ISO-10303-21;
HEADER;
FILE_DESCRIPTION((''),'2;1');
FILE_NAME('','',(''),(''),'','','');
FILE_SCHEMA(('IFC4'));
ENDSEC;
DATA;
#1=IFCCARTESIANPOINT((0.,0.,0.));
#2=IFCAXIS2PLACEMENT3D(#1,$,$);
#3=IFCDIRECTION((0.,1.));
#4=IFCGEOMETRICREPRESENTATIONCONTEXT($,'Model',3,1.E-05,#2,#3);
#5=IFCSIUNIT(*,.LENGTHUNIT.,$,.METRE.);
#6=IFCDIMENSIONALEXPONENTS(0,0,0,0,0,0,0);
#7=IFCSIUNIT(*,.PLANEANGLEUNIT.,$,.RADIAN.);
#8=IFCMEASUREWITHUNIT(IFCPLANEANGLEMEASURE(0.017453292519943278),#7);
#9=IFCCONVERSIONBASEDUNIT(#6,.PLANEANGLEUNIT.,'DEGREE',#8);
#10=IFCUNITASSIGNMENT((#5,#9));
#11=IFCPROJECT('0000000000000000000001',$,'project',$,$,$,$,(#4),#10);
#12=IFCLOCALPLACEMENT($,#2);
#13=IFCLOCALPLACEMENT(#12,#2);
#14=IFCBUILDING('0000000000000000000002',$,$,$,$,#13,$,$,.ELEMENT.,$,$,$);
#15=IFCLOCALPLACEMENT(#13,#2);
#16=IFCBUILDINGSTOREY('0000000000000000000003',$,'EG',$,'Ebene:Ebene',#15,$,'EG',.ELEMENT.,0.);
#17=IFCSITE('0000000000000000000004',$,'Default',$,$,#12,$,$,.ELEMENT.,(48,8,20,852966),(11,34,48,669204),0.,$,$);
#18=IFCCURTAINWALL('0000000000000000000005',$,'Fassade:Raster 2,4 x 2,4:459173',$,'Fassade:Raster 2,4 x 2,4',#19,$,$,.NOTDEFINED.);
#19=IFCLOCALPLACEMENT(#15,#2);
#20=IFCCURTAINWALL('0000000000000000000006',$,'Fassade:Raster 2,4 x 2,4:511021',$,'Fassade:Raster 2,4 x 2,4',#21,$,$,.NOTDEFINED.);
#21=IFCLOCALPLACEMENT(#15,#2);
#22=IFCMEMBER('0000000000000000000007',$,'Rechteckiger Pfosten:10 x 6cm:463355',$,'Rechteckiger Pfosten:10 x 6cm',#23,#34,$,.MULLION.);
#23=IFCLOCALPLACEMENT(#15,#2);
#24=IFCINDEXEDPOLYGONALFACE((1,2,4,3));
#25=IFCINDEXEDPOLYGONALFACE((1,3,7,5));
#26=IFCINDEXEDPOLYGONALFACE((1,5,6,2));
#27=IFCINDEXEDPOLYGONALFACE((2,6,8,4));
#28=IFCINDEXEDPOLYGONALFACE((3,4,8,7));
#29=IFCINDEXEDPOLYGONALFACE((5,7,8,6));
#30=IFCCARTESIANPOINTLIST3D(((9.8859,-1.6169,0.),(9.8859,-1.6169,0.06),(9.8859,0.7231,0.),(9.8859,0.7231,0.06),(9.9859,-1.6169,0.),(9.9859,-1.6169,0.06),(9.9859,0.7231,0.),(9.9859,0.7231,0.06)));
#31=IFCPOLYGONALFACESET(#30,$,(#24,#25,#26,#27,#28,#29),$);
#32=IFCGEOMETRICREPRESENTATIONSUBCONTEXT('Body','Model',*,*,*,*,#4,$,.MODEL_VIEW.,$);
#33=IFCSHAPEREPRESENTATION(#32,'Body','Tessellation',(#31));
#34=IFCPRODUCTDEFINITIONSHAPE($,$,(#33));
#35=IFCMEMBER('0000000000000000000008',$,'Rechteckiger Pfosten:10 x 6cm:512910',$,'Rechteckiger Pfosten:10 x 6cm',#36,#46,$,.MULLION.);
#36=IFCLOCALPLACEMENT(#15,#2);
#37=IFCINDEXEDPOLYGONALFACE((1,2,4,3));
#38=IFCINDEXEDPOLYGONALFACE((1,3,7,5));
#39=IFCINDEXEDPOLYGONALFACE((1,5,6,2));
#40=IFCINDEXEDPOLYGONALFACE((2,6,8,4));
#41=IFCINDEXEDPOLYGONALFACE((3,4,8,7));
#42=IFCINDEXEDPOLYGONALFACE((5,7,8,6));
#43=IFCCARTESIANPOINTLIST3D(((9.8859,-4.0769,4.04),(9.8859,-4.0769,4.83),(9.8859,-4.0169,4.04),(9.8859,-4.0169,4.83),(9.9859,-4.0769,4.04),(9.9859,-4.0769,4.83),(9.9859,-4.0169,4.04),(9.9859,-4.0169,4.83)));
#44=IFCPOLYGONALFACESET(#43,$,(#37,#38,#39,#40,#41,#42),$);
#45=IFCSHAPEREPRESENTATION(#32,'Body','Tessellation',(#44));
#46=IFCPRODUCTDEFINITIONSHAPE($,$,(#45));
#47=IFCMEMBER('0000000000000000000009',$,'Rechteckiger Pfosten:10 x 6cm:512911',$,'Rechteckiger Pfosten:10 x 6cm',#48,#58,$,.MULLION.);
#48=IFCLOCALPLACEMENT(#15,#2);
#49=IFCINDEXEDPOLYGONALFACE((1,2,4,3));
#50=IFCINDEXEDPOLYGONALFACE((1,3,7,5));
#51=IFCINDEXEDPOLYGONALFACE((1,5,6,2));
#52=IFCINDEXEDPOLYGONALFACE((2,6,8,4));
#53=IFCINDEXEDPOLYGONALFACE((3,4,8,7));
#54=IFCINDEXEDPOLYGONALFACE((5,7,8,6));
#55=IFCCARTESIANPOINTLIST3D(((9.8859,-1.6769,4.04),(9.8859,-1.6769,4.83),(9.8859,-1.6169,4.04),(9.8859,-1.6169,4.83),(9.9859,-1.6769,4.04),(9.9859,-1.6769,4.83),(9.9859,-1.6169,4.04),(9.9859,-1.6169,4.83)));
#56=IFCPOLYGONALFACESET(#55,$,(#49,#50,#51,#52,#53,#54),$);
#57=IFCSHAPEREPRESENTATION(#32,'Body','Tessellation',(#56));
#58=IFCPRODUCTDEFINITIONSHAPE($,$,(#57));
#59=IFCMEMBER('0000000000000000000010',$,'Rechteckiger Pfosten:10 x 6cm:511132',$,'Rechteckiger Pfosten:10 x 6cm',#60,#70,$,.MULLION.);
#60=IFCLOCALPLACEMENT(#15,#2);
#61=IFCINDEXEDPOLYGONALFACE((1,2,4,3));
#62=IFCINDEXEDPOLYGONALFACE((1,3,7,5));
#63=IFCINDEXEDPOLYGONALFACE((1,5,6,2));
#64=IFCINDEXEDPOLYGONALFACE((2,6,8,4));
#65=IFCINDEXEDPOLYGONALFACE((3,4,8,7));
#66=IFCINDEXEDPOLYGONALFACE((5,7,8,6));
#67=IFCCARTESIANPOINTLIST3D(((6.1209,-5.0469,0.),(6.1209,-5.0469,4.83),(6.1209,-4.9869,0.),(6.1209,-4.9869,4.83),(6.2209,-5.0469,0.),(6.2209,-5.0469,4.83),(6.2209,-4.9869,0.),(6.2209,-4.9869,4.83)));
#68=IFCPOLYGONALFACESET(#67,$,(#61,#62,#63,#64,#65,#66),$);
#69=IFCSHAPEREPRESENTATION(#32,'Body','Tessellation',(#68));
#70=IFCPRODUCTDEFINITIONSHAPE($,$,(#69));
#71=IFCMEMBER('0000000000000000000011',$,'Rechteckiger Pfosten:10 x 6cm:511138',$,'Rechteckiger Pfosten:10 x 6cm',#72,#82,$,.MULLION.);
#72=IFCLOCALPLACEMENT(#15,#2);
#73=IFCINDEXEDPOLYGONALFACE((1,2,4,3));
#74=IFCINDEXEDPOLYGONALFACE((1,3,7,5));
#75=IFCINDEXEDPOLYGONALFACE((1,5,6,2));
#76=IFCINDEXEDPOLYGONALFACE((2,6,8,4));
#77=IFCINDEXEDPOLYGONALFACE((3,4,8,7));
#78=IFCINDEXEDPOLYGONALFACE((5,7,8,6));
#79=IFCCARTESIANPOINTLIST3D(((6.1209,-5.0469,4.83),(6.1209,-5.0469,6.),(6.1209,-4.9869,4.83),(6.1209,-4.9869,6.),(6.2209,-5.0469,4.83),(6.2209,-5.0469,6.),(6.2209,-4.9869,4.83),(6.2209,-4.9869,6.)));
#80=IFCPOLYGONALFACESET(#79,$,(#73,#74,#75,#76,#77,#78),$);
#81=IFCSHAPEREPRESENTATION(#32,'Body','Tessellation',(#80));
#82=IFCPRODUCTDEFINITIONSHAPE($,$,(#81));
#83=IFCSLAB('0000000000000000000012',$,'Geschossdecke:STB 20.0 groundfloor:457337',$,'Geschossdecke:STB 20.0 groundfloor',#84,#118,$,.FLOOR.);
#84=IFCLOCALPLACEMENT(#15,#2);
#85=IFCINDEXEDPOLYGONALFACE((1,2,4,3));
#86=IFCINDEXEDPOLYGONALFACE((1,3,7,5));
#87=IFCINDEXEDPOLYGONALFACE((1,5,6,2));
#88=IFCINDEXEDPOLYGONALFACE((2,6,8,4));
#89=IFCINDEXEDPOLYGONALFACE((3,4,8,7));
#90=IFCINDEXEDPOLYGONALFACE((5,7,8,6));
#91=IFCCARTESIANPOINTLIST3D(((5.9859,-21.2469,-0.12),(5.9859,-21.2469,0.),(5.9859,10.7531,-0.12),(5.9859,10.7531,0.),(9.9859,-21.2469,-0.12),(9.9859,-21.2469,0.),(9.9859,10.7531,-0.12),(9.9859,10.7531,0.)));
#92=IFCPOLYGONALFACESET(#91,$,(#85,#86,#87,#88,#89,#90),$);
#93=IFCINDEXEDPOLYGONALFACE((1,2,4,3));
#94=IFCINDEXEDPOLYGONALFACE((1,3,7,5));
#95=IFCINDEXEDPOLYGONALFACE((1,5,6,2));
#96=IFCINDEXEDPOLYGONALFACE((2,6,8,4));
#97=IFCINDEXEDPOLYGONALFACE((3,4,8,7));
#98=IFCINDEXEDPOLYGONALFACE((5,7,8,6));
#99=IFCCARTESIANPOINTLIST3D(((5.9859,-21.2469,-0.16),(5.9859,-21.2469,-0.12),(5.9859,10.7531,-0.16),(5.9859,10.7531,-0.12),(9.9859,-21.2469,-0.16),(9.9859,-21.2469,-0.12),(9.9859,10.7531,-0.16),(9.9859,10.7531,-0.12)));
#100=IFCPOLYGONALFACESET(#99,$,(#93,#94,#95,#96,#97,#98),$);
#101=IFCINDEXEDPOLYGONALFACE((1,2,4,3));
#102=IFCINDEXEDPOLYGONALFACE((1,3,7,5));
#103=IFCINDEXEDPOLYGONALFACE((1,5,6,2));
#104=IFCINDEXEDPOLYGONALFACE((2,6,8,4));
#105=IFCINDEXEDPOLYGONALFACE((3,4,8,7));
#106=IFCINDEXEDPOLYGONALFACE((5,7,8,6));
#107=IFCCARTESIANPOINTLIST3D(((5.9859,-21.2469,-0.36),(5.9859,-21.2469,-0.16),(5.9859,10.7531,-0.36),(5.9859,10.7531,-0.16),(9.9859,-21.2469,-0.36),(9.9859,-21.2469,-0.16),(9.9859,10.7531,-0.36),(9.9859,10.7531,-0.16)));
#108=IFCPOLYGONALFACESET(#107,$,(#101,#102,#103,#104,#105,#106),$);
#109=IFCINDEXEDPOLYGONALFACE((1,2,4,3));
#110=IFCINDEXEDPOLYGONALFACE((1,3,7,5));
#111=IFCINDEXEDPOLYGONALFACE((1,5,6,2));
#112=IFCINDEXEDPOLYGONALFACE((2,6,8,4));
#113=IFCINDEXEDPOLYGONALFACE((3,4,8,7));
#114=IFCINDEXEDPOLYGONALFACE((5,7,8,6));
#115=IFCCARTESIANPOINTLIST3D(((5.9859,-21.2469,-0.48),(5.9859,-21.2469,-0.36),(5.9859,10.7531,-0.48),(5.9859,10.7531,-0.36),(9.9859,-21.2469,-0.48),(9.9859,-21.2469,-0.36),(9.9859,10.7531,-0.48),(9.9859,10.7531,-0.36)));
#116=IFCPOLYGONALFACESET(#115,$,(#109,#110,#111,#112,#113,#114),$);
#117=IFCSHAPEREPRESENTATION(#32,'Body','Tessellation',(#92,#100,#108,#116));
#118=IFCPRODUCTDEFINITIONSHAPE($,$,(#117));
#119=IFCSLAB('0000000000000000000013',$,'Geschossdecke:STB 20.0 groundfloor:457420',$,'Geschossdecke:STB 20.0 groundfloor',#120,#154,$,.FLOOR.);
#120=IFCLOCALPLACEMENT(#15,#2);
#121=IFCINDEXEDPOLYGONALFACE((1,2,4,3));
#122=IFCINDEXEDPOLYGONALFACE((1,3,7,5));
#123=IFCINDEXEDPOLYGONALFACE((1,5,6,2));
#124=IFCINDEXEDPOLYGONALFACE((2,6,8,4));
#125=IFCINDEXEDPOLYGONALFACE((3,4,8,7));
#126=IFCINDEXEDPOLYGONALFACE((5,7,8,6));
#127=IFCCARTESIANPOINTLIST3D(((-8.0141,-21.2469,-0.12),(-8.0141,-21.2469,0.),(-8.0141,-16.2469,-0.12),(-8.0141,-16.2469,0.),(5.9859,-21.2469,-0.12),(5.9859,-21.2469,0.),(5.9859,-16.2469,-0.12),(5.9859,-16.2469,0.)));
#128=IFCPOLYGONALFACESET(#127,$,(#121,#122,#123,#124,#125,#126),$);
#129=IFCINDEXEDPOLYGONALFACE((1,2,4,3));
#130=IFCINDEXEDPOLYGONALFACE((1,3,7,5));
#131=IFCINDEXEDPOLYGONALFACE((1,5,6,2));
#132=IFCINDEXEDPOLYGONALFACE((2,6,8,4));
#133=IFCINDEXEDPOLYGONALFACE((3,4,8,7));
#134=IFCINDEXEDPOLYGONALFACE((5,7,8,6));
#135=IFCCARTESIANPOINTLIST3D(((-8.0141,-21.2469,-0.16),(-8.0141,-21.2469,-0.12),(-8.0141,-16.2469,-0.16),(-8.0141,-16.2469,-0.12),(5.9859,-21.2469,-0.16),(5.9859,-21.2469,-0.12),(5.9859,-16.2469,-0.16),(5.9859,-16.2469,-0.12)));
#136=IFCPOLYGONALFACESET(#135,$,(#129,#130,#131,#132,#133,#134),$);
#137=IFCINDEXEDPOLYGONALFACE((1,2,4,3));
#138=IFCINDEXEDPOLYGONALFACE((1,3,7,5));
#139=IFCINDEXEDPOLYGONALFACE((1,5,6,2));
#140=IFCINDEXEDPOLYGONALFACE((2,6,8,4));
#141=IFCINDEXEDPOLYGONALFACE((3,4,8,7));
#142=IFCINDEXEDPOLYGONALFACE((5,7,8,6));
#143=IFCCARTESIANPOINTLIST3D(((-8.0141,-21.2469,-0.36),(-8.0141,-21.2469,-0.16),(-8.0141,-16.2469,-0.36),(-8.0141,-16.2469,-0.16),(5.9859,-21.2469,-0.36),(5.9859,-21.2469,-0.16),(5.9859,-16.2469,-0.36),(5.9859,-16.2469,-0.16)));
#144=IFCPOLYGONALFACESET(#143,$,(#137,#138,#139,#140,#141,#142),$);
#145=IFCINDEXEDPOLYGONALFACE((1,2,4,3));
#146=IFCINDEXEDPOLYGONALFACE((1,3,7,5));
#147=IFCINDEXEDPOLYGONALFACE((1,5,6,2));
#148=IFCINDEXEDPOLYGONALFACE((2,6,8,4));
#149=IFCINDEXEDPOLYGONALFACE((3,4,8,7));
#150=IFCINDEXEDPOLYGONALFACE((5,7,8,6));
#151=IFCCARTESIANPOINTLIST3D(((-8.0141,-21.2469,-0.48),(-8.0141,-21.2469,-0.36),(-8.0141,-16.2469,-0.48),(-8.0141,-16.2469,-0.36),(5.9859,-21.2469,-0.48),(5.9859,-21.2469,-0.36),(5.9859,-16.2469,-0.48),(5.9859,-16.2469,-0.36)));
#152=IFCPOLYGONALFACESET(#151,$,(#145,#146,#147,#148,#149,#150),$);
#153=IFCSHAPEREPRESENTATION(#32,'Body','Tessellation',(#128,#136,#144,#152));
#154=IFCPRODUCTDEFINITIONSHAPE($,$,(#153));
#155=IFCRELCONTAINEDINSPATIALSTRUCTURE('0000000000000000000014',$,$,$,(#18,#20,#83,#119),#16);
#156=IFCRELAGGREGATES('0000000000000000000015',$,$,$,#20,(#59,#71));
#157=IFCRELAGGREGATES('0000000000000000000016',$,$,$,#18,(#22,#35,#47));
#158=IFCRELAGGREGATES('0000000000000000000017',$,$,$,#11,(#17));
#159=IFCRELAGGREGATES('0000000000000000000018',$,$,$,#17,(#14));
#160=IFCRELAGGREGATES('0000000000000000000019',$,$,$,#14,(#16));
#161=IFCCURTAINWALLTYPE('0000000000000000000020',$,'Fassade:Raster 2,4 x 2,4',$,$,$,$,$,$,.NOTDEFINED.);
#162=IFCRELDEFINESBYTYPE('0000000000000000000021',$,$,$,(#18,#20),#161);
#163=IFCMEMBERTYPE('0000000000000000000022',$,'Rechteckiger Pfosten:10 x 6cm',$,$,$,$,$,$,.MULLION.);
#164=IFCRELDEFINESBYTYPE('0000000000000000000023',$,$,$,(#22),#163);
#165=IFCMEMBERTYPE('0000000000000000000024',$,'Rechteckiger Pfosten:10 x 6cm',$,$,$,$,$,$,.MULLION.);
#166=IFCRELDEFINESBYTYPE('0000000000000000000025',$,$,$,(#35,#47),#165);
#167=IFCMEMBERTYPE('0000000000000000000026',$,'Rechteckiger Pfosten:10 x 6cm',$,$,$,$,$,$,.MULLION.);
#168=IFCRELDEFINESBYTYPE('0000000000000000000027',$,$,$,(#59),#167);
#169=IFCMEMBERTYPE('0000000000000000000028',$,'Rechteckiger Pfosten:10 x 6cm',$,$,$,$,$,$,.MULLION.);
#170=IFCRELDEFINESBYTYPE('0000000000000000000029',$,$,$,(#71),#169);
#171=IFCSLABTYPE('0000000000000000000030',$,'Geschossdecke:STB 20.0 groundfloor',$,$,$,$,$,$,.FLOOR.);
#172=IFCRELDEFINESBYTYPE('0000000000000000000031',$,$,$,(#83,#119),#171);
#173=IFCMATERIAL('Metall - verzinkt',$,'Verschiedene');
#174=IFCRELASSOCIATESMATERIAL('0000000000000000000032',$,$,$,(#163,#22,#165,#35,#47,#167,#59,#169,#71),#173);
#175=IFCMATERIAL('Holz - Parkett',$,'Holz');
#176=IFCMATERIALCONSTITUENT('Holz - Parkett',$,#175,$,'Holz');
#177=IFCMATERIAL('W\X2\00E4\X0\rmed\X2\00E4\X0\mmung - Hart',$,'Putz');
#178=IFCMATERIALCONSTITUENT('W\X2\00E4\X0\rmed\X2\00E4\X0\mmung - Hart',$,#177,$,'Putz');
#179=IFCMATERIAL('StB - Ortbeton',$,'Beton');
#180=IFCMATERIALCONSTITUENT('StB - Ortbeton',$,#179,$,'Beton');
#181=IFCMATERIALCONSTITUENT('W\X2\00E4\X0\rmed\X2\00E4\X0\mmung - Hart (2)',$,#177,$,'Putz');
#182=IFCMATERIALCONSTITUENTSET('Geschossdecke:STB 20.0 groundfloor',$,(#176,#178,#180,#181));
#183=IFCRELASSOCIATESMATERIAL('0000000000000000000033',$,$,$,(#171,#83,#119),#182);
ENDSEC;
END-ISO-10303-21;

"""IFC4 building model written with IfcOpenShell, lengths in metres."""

from ifc_helpers import new_model, entity, si_unit, converted_unit, direction, frame, origin, place, context, subcontext, project, spatial, indexed_curve, outline, extrude, source, transform, mapped, material, constituent, constituent_set, type_object, type_shapes, element, aggregate, save


model = new_model("IFC4")

# Units and contexts
model_context = context("Model", 3, precision=1e-05, world=origin(), true_north=direction((0.0, 1.0)))
body_context = subcontext(model_context, "Body", "Model", "MODEL_VIEW")
ifc_project = project(units=[si_unit("LENGTHUNIT", "METRE"), converted_unit("PLANEANGLEUNIT", "DEGREE", entity("IfcPlaneAngleMeasure", 0.017453292519943278), si_unit("PLANEANGLEUNIT", "RADIAN"), dimensions=[0, 0, 0, 0, 0, 0, 0])], contexts=[model_context])

# Site, building, storey
site_placement = place(None, origin())
site = spatial("IfcSite", under=ifc_project, at=site_placement, Name="Default", CompositionType="ELEMENT", RefLatitude=(48, 8, 20, 852966), RefLongitude=(11, 34, 48, 669204), RefElevation=0.0)
building_placement = place(site_placement, origin())
building = spatial("IfcBuilding", under=site, at=building_placement, CompositionType="ELEMENT")
storey_placement = place(building_placement, origin())
storey = spatial("IfcBuildingStorey", under=building, at=storey_placement, Name="EG", ObjectType="Ebene:Ebene", LongName="EG", CompositionType="ELEMENT", Elevation=0.0)

# Curtain wall
curtain_wall_type = type_object("IfcCurtainWallType", Name="Fassade:Raster 2,4 x 2,4", PredefinedType="NOTDEFINED")
curtain_wall_1_placement = place(storey_placement, origin())
curtain_wall_1 = element("IfcCurtainWall", 1, at=curtain_wall_1_placement, inside=storey, type_object=curtain_wall_type, Name="Fassade:Raster 2,4 x 2,4:459173", ObjectType="Fassade:Raster 2,4 x 2,4", PredefinedType="NOTDEFINED")
ifc_material_1 = material(Name="Metall - verzinkt", Category="Verschiedene")

# Curtain wall
curtain_wall_2_placement = place(storey_placement, origin())
curtain_wall_2 = element("IfcCurtainWall", 2, at=curtain_wall_2_placement, inside=storey, type_object=curtain_wall_type, Name="Fassade:Raster 2,4 x 2,4:511021", ObjectType="Fassade:Raster 2,4 x 2,4", PredefinedType="NOTDEFINED")

# Members
member_type_1 = type_object("IfcMemberType", Name="Rechteckiger Pfosten:10 x 6cm", PredefinedType="MULLION", material=ifc_material_1)
shared_shape_1 = source(origin(), body_context, "Body", "SweptSolid", [
    extrude(outline(indexed_curve([(-0.03, -0.05), (0.03, -0.05), (0.03, 0.05), (-0.03, 0.05), (-0.03, -0.05)], self_intersect=False)), frame((-0.03, 0.0, -2.34), z_axis=(0.0, 0.0, 1.0), x_axis=(-1.0, 0.0, 0.0)), (0.0, 0.0, 1.0), 2.34),
])
type_shapes(member_type_1, [shared_shape_1])
member_1_placement = place(curtain_wall_1_placement, frame((9.9359, -1.6169, 0.0), z_axis=(0.0, -1.0, 0.0), x_axis=(0.0, 0.0, -1.0)))
member_1 = element("IfcMember", 3, at=member_1_placement, type_object=member_type_1, material=ifc_material_1, Name="Rechteckiger Pfosten:10 x 6cm:463355", ObjectType="Rechteckiger Pfosten:10 x 6cm", PredefinedType="MULLION", context=body_context, shape_type="MappedRepresentation", body=[
    mapped(shared_shape_1, transform((0.0, 0.0, 0.0), scale=1.0)),
])
member_type_2 = type_object("IfcMemberType", Name="Rechteckiger Pfosten:10 x 6cm", PredefinedType="MULLION", material=ifc_material_1)
shared_shape_2 = source(origin(), body_context, "Body", "SweptSolid", [
    extrude(outline(indexed_curve([(-0.03, -0.05), (0.03, -0.05), (0.03, 0.05), (-0.03, 0.05), (-0.03, -0.05)], self_intersect=False)), frame((0.0, 0.0, -0.79), z_axis=(0.0, 0.0, 1.0), x_axis=(-1.0, 0.0, 0.0)), (0.0, 0.0, 1.0), 0.79),
])
type_shapes(member_type_2, [shared_shape_2])
member_2_placement = place(curtain_wall_1_placement, frame((9.9359, -4.0469, 4.04), z_axis=(0.0, 0.0, -1.0), x_axis=(0.0, 1.0, 0.0)))
member_2 = element("IfcMember", 4, at=member_2_placement, type_object=member_type_2, material=ifc_material_1, Name="Rechteckiger Pfosten:10 x 6cm:512910", ObjectType="Rechteckiger Pfosten:10 x 6cm", PredefinedType="MULLION", context=body_context, shape_type="MappedRepresentation", body=[
    mapped(shared_shape_2, transform((0.0, 0.0, 0.0), scale=1.0)),
])
member_3_placement = place(curtain_wall_1_placement, frame((9.9359, -1.6469, 4.04), z_axis=(0.0, 0.0, -1.0), x_axis=(0.0, 1.0, 0.0)))
member_3 = element("IfcMember", 5, at=member_3_placement, type_object=member_type_2, material=ifc_material_1, Name="Rechteckiger Pfosten:10 x 6cm:512911", ObjectType="Rechteckiger Pfosten:10 x 6cm", PredefinedType="MULLION", context=body_context, shape_type="MappedRepresentation", body=[
    mapped(shared_shape_2, transform((0.0, 0.0, 0.0), scale=1.0)),
])
member_type_3 = type_object("IfcMemberType", Name="Rechteckiger Pfosten:10 x 6cm", PredefinedType="MULLION", material=ifc_material_1)
shared_shape_3 = source(origin(), body_context, "Body", "SweptSolid", [
    extrude(outline(indexed_curve([(-0.03, -0.05), (0.03, -0.05), (0.03, 0.05), (-0.03, 0.05), (-0.03, -0.05)], self_intersect=False)), frame((0.0, 0.0, -4.83), z_axis=(0.0, 0.0, 1.0), x_axis=(-1.0, 0.0, 0.0)), (0.0, 0.0, 1.0), 4.83),
])
type_shapes(member_type_3, [shared_shape_3])
member_4_placement = place(curtain_wall_2_placement, frame((6.1709, -5.0169, 0.0), z_axis=(0.0, 0.0, -1.0), x_axis=(0.0, 1.0, 0.0)))
member_4 = element("IfcMember", 6, at=member_4_placement, type_object=member_type_3, material=ifc_material_1, Name="Rechteckiger Pfosten:10 x 6cm:511132", ObjectType="Rechteckiger Pfosten:10 x 6cm", PredefinedType="MULLION", context=body_context, shape_type="MappedRepresentation", body=[
    mapped(shared_shape_3, transform((0.0, 0.0, 0.0), scale=1.0)),
])
member_type_4 = type_object("IfcMemberType", Name="Rechteckiger Pfosten:10 x 6cm", PredefinedType="MULLION", material=ifc_material_1)
shared_shape_4 = source(origin(), body_context, "Body", "SweptSolid", [
    extrude(outline(indexed_curve([(-0.03, -0.05), (0.03, -0.05), (0.03, 0.05), (-0.03, 0.05), (-0.03, -0.05)], self_intersect=False)), frame((0.0, 0.0, -1.17), z_axis=(0.0, 0.0, 1.0), x_axis=(-1.0, 0.0, 0.0)), (0.0, 0.0, 1.0), 1.17),
])
type_shapes(member_type_4, [shared_shape_4])
member_5_placement = place(curtain_wall_2_placement, frame((6.1709, -5.0169, 4.83), z_axis=(0.0, 0.0, -1.0), x_axis=(0.0, 1.0, 0.0)))
member_5 = element("IfcMember", 7, at=member_5_placement, type_object=member_type_4, material=ifc_material_1, Name="Rechteckiger Pfosten:10 x 6cm:511138", ObjectType="Rechteckiger Pfosten:10 x 6cm", PredefinedType="MULLION", context=body_context, shape_type="MappedRepresentation", body=[
    mapped(shared_shape_4, transform((0.0, 0.0, 0.0), scale=1.0)),
])
aggregate(curtain_wall_2, [member_4, member_5])

# Slabs
ifc_material_2 = material(Name="Holz - Parkett", Category="Holz")
ifc_constituent_1 = constituent(ifc_material_2, Name="Holz - Parkett", Category="Holz")
ifc_material_3 = material(Name="Wärmedämmung - Hart", Category="Putz")
ifc_constituent_2 = constituent(ifc_material_3, Name="Wärmedämmung - Hart", Category="Putz")
ifc_material_4 = material(Name="StB - Ortbeton", Category="Beton")
ifc_constituent_3 = constituent(ifc_material_4, Name="StB - Ortbeton", Category="Beton")
ifc_constituent_4 = constituent(ifc_material_3, Name="Wärmedämmung - Hart (2)", Category="Putz")
ifc_constituent_set = constituent_set(constituents=[ifc_constituent_1, ifc_constituent_2, ifc_constituent_3, ifc_constituent_4], Name="Geschossdecke:STB 20.0 groundfloor")
slab_type = type_object("IfcSlabType", Name="Geschossdecke:STB 20.0 groundfloor", PredefinedType="FLOOR", material=ifc_constituent_set)
slab_1_placement = place(storey_placement, origin())
element("IfcSlab", 8, at=slab_1_placement, inside=storey, type_object=slab_type, material=ifc_constituent_set, Name="Geschossdecke:STB 20.0 groundfloor:457337", ObjectType="Geschossdecke:STB 20.0 groundfloor", PredefinedType="FLOOR", context=body_context, shape_type="SweptSolid", body=[
    extrude(outline(indexed_curve([(-2.0, -16.0), (2.0, -16.0), (2.0, 16.0), (-2.0, 16.0), (-2.0, -16.0)], self_intersect=False)), frame((7.9859, -5.2469, -0.12), z_axis=(0.0, 0.0, 1.0), x_axis=(-1.0, 0.0, 0.0)), (0.0, 0.0, 1.0), 0.12),
    extrude(outline(indexed_curve([(-2.0, -16.0), (2.0, -16.0), (2.0, 16.0), (-2.0, 16.0), (-2.0, -16.0)], self_intersect=False)), frame((7.9859, -5.2469, -0.16), z_axis=(0.0, 0.0, 1.0), x_axis=(-1.0, 0.0, 0.0)), (0.0, 0.0, 1.0), 0.04),
    extrude(outline(indexed_curve([(-2.0, -16.0), (2.0, -16.0), (2.0, 16.0), (-2.0, 16.0), (-2.0, -16.0)], self_intersect=False)), frame((7.9859, -5.2469, -0.36), z_axis=(0.0, 0.0, 1.0), x_axis=(-1.0, 0.0, 0.0)), (0.0, 0.0, 1.0), 0.2),
    extrude(outline(indexed_curve([(-2.0, -16.0), (2.0, -16.0), (2.0, 16.0), (-2.0, 16.0), (-2.0, -16.0)], self_intersect=False)), frame((7.9859, -5.2469, -0.48), z_axis=(0.0, 0.0, 1.0), x_axis=(-1.0, 0.0, 0.0)), (0.0, 0.0, 1.0), 0.12),
])
slab_2_placement = place(storey_placement, origin())
element("IfcSlab", 9, at=slab_2_placement, inside=storey, type_object=slab_type, material=ifc_constituent_set, Name="Geschossdecke:STB 20.0 groundfloor:457420", ObjectType="Geschossdecke:STB 20.0 groundfloor", PredefinedType="FLOOR", context=body_context, shape_type="SweptSolid", body=[
    extrude(outline(indexed_curve([(-7.0, -2.5), (7.0, -2.5), (7.0, 2.5), (-7.0, 2.5), (-7.0, -2.5)], self_intersect=False)), frame((-1.0141, -18.7469, -0.12), z_axis=(0.0, 0.0, 1.0), x_axis=(-1.0, 0.0, 0.0)), (0.0, 0.0, 1.0), 0.12),
    extrude(outline(indexed_curve([(-7.0, -2.5), (7.0, -2.5), (7.0, 2.5), (-7.0, 2.5), (-7.0, -2.5)], self_intersect=False)), frame((-1.0141, -18.7469, -0.16), z_axis=(0.0, 0.0, 1.0), x_axis=(-1.0, 0.0, 0.0)), (0.0, 0.0, 1.0), 0.04),
    extrude(outline(indexed_curve([(-7.0, -2.5), (7.0, -2.5), (7.0, 2.5), (-7.0, 2.5), (-7.0, -2.5)], self_intersect=False)), frame((-1.0141, -18.7469, -0.36), z_axis=(0.0, 0.0, 1.0), x_axis=(-1.0, 0.0, 0.0)), (0.0, 0.0, 1.0), 0.2),
    extrude(outline(indexed_curve([(-7.0, -2.5), (7.0, -2.5), (7.0, 2.5), (-7.0, 2.5), (-7.0, -2.5)], self_intersect=False)), frame((-1.0141, -18.7469, -0.48), z_axis=(0.0, 0.0, 1.0), x_axis=(-1.0, 0.0, 0.0)), (0.0, 0.0, 1.0), 0.12),
])

aggregate(curtain_wall_1, [member_1, member_2, member_3])

save(model, "model.ifc")
